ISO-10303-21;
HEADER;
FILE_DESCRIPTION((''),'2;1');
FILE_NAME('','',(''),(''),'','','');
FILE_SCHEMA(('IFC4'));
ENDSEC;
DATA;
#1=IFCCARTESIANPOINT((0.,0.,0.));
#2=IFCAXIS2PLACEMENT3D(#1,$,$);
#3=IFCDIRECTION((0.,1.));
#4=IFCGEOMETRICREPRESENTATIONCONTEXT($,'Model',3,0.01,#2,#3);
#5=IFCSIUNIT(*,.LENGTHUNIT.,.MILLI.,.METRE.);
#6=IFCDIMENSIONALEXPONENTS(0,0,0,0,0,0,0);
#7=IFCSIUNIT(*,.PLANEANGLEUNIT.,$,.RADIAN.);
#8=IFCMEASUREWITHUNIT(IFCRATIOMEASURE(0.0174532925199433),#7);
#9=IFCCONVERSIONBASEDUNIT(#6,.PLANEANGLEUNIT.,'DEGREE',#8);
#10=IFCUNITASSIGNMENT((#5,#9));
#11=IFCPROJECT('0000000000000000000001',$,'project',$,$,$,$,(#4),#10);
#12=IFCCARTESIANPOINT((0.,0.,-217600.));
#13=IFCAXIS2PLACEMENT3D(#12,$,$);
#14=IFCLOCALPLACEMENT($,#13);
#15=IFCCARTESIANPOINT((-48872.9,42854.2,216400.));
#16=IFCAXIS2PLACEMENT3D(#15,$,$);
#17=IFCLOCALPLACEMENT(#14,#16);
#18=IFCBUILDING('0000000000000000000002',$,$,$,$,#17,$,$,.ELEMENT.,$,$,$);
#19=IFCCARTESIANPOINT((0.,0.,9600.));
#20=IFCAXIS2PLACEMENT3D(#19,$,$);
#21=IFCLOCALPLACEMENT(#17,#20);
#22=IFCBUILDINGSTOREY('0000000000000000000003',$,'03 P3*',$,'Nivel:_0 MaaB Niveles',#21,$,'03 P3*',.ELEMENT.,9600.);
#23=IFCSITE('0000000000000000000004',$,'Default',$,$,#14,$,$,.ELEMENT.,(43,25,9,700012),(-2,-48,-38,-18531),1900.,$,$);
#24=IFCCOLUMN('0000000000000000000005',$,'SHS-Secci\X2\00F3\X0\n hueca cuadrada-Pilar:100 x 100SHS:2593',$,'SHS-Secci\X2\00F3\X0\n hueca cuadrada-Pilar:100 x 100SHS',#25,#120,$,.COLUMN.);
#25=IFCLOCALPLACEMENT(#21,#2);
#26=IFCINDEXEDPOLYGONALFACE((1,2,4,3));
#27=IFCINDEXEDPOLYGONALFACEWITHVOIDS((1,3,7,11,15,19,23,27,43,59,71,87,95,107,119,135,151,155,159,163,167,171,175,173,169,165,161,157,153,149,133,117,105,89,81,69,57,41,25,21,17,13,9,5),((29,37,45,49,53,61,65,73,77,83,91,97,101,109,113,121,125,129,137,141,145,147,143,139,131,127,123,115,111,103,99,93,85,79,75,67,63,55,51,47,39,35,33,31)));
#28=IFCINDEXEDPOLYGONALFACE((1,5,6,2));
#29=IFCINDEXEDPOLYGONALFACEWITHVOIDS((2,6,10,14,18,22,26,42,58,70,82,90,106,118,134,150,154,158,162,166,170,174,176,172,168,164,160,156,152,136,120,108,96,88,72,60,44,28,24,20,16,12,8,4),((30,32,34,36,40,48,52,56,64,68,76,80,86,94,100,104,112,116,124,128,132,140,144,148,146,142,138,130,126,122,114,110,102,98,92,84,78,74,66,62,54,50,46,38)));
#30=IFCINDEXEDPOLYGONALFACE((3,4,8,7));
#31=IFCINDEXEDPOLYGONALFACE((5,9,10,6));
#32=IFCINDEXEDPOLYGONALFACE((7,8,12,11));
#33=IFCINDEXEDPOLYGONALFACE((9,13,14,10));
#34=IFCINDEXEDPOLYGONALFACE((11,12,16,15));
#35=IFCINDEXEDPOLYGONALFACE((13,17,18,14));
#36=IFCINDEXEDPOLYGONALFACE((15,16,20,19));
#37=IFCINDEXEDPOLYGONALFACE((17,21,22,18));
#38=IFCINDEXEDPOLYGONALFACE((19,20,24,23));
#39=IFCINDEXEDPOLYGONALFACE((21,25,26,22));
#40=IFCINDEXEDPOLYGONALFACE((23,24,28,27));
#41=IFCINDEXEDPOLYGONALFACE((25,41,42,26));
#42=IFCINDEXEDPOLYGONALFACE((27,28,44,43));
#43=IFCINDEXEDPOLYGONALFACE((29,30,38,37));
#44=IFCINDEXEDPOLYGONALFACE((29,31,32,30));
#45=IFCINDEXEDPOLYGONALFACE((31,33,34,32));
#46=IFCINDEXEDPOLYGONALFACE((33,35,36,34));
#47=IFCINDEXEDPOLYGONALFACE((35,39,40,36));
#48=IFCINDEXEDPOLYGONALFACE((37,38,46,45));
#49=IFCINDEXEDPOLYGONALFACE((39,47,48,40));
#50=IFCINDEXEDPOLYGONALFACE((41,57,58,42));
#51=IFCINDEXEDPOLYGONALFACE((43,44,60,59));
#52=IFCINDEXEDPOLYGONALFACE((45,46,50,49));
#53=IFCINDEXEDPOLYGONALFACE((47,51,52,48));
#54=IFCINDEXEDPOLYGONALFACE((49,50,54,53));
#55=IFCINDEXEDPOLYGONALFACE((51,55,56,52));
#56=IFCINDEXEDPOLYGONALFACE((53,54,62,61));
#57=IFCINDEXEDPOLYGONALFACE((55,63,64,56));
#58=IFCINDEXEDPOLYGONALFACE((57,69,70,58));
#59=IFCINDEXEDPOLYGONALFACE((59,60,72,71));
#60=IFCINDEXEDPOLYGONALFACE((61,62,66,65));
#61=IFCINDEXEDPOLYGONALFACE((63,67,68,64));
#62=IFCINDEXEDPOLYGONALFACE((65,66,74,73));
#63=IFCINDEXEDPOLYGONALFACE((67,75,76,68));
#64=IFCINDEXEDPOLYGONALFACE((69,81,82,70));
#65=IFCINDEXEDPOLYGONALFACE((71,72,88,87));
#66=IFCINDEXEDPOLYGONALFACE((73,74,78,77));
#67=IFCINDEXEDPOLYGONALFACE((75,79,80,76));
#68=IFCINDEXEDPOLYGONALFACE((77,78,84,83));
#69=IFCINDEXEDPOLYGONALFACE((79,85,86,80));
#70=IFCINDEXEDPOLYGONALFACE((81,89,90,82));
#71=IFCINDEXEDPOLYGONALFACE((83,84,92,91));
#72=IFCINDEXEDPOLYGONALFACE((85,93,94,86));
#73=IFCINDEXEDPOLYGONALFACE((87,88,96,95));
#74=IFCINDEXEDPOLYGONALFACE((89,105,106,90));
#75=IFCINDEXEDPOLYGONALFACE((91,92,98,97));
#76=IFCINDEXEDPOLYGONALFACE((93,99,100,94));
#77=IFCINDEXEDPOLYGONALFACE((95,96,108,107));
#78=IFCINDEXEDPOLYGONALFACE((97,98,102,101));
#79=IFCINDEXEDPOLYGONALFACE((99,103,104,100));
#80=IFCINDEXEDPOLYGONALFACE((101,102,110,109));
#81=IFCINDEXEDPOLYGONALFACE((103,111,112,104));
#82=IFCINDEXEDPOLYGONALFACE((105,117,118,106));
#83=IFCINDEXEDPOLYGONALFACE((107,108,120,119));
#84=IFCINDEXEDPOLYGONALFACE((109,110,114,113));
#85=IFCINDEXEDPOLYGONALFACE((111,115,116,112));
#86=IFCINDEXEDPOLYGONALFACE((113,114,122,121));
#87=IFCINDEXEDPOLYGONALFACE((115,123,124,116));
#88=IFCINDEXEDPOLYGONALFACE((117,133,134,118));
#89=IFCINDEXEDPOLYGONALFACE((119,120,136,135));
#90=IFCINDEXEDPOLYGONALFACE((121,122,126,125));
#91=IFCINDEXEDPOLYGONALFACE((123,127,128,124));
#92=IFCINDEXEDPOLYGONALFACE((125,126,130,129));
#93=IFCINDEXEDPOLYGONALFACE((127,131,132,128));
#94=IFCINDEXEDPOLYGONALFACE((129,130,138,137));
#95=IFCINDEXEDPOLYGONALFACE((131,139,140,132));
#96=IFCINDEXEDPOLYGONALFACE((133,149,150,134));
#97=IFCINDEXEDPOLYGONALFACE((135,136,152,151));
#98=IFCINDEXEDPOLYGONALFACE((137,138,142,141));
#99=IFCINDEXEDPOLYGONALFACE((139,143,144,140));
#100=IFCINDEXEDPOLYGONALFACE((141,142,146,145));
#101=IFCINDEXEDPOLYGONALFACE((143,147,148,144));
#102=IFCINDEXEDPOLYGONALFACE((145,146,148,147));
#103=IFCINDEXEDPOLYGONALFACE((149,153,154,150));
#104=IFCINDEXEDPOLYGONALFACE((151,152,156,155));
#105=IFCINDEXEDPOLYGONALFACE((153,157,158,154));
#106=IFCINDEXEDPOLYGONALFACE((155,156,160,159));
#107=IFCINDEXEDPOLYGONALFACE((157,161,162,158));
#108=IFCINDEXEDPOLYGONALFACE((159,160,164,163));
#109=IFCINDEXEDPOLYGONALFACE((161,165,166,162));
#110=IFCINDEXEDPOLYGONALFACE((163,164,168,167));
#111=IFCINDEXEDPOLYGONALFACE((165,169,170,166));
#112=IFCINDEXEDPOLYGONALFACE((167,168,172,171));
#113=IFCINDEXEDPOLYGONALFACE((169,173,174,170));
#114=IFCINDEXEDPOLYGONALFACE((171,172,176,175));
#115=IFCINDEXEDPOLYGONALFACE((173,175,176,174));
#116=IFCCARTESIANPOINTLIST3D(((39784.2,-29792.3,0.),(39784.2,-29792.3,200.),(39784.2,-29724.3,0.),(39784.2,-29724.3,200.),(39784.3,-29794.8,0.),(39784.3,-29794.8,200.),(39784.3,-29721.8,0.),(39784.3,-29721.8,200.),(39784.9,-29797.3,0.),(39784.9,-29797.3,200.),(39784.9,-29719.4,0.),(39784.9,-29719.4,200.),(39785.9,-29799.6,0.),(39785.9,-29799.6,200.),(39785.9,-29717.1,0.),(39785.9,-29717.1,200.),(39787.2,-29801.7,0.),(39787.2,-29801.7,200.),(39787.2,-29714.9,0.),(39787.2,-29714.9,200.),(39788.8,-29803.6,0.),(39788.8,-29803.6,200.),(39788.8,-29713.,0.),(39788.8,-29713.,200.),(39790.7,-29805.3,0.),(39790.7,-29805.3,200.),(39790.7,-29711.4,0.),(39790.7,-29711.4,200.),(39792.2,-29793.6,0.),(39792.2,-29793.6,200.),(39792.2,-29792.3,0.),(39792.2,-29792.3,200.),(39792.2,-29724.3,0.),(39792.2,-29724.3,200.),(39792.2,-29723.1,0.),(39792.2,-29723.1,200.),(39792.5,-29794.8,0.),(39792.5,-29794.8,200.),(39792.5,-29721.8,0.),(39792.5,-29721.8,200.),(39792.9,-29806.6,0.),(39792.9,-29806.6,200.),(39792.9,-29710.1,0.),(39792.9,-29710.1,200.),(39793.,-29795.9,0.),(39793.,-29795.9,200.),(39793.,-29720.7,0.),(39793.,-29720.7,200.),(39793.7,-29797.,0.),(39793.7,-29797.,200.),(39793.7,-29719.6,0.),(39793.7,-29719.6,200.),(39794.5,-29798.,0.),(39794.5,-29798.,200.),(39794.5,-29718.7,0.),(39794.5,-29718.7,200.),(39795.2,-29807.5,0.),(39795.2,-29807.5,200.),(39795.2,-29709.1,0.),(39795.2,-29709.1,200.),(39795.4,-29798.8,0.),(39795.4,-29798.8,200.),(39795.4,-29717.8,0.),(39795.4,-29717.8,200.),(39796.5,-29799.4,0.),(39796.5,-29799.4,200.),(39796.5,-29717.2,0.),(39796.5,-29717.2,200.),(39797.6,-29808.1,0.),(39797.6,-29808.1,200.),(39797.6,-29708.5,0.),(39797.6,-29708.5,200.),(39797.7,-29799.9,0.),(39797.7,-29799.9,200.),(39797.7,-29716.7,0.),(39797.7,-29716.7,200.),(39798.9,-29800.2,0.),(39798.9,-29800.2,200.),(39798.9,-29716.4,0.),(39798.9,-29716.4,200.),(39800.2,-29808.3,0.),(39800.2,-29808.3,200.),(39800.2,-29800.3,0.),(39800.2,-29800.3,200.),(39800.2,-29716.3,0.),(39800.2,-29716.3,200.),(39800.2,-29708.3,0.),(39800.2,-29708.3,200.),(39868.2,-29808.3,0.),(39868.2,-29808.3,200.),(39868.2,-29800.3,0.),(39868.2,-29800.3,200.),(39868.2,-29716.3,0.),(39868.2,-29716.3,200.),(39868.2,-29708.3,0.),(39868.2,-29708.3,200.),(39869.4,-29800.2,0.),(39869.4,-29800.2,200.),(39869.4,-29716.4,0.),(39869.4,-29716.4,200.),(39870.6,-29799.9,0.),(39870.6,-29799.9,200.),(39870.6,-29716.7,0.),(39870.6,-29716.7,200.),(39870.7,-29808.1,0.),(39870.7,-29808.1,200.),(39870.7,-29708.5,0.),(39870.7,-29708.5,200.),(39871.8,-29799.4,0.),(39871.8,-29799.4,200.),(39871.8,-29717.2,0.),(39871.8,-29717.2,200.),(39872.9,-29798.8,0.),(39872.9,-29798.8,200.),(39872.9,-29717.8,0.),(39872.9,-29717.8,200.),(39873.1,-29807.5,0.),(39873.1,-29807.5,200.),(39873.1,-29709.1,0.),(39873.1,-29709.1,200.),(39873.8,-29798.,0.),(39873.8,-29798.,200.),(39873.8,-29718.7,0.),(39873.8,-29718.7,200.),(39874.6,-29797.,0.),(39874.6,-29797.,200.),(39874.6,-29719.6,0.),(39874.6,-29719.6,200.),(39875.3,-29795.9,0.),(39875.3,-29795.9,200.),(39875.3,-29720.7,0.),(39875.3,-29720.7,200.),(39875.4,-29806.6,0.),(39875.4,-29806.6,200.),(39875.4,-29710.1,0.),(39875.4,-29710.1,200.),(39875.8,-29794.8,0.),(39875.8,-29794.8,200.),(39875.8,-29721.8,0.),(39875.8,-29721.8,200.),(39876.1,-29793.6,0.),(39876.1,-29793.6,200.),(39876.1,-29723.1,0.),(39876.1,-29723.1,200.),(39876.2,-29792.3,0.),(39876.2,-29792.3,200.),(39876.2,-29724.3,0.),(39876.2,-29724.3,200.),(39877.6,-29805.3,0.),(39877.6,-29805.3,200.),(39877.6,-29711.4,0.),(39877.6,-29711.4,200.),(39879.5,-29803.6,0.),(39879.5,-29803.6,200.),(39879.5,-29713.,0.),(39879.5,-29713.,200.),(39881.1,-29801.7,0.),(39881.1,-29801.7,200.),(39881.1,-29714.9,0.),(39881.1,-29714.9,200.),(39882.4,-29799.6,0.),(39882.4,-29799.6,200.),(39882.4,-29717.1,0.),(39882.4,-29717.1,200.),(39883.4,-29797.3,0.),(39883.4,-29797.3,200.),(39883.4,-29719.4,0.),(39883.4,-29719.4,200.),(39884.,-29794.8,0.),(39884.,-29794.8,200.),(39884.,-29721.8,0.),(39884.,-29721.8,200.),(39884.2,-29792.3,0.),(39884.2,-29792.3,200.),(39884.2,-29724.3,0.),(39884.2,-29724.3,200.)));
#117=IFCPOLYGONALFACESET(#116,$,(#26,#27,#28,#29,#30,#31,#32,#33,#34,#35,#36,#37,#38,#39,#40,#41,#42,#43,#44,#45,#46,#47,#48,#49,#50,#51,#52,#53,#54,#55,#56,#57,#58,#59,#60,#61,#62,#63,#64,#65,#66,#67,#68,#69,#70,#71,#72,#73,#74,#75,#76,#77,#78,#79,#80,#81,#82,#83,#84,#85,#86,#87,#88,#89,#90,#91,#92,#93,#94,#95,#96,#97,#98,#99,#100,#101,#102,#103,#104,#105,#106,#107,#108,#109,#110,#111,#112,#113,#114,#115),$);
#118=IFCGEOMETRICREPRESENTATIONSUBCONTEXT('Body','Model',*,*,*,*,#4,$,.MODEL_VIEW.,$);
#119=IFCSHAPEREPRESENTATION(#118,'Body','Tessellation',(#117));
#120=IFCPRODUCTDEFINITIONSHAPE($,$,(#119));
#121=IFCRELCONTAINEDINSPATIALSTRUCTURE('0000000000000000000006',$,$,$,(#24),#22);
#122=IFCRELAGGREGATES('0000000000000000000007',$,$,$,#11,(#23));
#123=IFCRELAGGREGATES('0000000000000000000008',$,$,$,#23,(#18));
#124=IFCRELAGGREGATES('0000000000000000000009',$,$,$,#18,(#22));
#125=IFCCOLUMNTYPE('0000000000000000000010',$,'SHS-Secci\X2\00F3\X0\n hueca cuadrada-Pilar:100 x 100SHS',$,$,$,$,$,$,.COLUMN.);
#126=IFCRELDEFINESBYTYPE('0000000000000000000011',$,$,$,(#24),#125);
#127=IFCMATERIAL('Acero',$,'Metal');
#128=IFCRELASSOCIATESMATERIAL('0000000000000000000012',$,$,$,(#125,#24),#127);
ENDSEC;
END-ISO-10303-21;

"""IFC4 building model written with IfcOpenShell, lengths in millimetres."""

from ifc_helpers import new_model, entity, si_unit, converted_unit, direction, frame, origin, place, context, subcontext, project, spatial, indexed_curve, outline, extrude, source, transform, mapped, material, type_object, type_shapes, element, save


model = new_model("IFC4")

# Units and contexts
model_context = context("Model", 3, precision=0.01, world=origin(), true_north=direction((0.0, 1.0)))
body_context = subcontext(model_context, "Body", "Model", "MODEL_VIEW")
ifc_project = project(units=[si_unit("LENGTHUNIT", "METRE", prefix="MILLI"), converted_unit("PLANEANGLEUNIT", "DEGREE", entity("IfcRatioMeasure", 0.0174532925199433), si_unit("PLANEANGLEUNIT", "RADIAN"), dimensions=[0, 0, 0, 0, 0, 0, 0])], contexts=[model_context])

# Site, building, storey
site_placement = place(None, frame((0.0, 0.0, -217600.0)))
site = spatial("IfcSite", under=ifc_project, at=site_placement, Name="Default", CompositionType="ELEMENT", RefLatitude=(43, 25, 9, 700012), RefLongitude=(-2, -48, -38, -18531), RefElevation=1900.0)
building_placement = place(site_placement, frame((-48872.9, 42854.2, 216400.0)))
building = spatial("IfcBuilding", under=site, at=building_placement, CompositionType="ELEMENT")
storey_placement = place(building_placement, frame((0.0, 0.0, 9600.0)))
storey = spatial("IfcBuildingStorey", under=building, at=storey_placement, Name="03 P3*", ObjectType="Nivel:_0 MaaB Niveles", LongName="03 P3*", CompositionType="ELEMENT", Elevation=9600.0)

# Column
ifc_material_1 = material(Name="Acero", Category="Metal")
column_type_1 = type_object("IfcColumnType", Name="SHS-Sección hueca cuadrada-Pilar:100 x 100SHS", PredefinedType="COLUMN", material=ifc_material_1)
shared_shape_1 = source(origin(), body_context, "Body", "SweptSolid", [
    extrude(outline(indexed_curve([(-34.0, -50.0), (34.0, -50.0), (36.5, -49.8), (38.9, -49.2), (41.3, -48.3), (43.4, -46.9), (45.3, -45.3), (46.9, -43.4), (48.3, -41.3), (49.2, -38.9), (49.8, -36.5), (50.0, -34.0), (50.0, 34.0), (49.8, 36.5), (49.2, 38.9), (48.3, 41.3), (46.9, 43.4), (45.3, 45.3), (43.4, 46.9), (41.3, 48.3), (38.9, 49.2), (36.5, 49.8), (34.0, 50.0), (-34.0, 50.0), (-36.5, 49.8), (-38.9, 49.2), (-41.3, 48.3), (-43.4, 46.9), (-45.3, 45.3), (-46.9, 43.4), (-48.3, 41.3), (-49.2, 38.9), (-49.8, 36.5), (-50.0, 34.0), (-50.0, -34.0), (-49.8, -36.5), (-49.2, -38.9), (-48.3, -41.3), (-46.9, -43.4), (-45.3, -45.3), (-43.4, -46.9), (-41.3, -48.3), (-38.9, -49.2), (-36.5, -49.8), (-34.0, -50.0)], self_intersect=False), holes=[indexed_curve([(-34.0, -42.0), (-35.3, -41.9), (-36.5, -41.6), (-37.6, -41.1), (-38.7, -40.5), (-39.7, -39.7), (-40.5, -38.7), (-41.1, -37.6), (-41.6, -36.5), (-41.9, -35.3), (-42.0, -34.0), (-42.0, 34.0), (-41.9, 35.3), (-41.6, 36.5), (-41.1, 37.6), (-40.5, 38.7), (-39.7, 39.7), (-38.7, 40.5), (-37.6, 41.1), (-36.5, 41.6), (-35.3, 41.9), (-34.0, 42.0), (34.0, 42.0), (35.3, 41.9), (36.5, 41.6), (37.6, 41.1), (38.7, 40.5), (39.7, 39.7), (40.5, 38.7), (41.1, 37.6), (41.6, 36.5), (41.9, 35.3), (42.0, 34.0), (42.0, -34.0), (41.9, -35.3), (41.6, -36.5), (41.1, -37.6), (40.5, -38.7), (39.7, -39.7), (38.7, -40.5), (37.6, -41.1), (36.5, -41.6), (35.3, -41.9), (34.0, -42.0), (-34.0, -42.0)], self_intersect=False)]), frame((0.0, 0.0, 9600.0), z_axis=(0.0, 0.0, 1.0), x_axis=(-1.0, 0.0, 0.0)), (0.0, 0.0, 1.0), 200.0),
])
type_shapes(column_type_1, [shared_shape_1])
column_1_placement = place(storey_placement, frame((39834.2, -29758.3, -9600.0), z_axis=(0.0, 0.0, 1.0), x_axis=(0.0, -1.0, 0.0)))
element("IfcColumn", 1, at=column_1_placement, inside=storey, type_object=column_type_1, material=ifc_material_1, Name="SHS-Sección hueca cuadrada-Pilar:100 x 100SHS:2593", ObjectType="SHS-Sección hueca cuadrada-Pilar:100 x 100SHS", PredefinedType="COLUMN", context=body_context, shape_type="MappedRepresentation", body=[
    mapped(shared_shape_1, transform((0.0, 0.0, 0.0), scale=1.0)),
])

save(model, "model.ifc")
